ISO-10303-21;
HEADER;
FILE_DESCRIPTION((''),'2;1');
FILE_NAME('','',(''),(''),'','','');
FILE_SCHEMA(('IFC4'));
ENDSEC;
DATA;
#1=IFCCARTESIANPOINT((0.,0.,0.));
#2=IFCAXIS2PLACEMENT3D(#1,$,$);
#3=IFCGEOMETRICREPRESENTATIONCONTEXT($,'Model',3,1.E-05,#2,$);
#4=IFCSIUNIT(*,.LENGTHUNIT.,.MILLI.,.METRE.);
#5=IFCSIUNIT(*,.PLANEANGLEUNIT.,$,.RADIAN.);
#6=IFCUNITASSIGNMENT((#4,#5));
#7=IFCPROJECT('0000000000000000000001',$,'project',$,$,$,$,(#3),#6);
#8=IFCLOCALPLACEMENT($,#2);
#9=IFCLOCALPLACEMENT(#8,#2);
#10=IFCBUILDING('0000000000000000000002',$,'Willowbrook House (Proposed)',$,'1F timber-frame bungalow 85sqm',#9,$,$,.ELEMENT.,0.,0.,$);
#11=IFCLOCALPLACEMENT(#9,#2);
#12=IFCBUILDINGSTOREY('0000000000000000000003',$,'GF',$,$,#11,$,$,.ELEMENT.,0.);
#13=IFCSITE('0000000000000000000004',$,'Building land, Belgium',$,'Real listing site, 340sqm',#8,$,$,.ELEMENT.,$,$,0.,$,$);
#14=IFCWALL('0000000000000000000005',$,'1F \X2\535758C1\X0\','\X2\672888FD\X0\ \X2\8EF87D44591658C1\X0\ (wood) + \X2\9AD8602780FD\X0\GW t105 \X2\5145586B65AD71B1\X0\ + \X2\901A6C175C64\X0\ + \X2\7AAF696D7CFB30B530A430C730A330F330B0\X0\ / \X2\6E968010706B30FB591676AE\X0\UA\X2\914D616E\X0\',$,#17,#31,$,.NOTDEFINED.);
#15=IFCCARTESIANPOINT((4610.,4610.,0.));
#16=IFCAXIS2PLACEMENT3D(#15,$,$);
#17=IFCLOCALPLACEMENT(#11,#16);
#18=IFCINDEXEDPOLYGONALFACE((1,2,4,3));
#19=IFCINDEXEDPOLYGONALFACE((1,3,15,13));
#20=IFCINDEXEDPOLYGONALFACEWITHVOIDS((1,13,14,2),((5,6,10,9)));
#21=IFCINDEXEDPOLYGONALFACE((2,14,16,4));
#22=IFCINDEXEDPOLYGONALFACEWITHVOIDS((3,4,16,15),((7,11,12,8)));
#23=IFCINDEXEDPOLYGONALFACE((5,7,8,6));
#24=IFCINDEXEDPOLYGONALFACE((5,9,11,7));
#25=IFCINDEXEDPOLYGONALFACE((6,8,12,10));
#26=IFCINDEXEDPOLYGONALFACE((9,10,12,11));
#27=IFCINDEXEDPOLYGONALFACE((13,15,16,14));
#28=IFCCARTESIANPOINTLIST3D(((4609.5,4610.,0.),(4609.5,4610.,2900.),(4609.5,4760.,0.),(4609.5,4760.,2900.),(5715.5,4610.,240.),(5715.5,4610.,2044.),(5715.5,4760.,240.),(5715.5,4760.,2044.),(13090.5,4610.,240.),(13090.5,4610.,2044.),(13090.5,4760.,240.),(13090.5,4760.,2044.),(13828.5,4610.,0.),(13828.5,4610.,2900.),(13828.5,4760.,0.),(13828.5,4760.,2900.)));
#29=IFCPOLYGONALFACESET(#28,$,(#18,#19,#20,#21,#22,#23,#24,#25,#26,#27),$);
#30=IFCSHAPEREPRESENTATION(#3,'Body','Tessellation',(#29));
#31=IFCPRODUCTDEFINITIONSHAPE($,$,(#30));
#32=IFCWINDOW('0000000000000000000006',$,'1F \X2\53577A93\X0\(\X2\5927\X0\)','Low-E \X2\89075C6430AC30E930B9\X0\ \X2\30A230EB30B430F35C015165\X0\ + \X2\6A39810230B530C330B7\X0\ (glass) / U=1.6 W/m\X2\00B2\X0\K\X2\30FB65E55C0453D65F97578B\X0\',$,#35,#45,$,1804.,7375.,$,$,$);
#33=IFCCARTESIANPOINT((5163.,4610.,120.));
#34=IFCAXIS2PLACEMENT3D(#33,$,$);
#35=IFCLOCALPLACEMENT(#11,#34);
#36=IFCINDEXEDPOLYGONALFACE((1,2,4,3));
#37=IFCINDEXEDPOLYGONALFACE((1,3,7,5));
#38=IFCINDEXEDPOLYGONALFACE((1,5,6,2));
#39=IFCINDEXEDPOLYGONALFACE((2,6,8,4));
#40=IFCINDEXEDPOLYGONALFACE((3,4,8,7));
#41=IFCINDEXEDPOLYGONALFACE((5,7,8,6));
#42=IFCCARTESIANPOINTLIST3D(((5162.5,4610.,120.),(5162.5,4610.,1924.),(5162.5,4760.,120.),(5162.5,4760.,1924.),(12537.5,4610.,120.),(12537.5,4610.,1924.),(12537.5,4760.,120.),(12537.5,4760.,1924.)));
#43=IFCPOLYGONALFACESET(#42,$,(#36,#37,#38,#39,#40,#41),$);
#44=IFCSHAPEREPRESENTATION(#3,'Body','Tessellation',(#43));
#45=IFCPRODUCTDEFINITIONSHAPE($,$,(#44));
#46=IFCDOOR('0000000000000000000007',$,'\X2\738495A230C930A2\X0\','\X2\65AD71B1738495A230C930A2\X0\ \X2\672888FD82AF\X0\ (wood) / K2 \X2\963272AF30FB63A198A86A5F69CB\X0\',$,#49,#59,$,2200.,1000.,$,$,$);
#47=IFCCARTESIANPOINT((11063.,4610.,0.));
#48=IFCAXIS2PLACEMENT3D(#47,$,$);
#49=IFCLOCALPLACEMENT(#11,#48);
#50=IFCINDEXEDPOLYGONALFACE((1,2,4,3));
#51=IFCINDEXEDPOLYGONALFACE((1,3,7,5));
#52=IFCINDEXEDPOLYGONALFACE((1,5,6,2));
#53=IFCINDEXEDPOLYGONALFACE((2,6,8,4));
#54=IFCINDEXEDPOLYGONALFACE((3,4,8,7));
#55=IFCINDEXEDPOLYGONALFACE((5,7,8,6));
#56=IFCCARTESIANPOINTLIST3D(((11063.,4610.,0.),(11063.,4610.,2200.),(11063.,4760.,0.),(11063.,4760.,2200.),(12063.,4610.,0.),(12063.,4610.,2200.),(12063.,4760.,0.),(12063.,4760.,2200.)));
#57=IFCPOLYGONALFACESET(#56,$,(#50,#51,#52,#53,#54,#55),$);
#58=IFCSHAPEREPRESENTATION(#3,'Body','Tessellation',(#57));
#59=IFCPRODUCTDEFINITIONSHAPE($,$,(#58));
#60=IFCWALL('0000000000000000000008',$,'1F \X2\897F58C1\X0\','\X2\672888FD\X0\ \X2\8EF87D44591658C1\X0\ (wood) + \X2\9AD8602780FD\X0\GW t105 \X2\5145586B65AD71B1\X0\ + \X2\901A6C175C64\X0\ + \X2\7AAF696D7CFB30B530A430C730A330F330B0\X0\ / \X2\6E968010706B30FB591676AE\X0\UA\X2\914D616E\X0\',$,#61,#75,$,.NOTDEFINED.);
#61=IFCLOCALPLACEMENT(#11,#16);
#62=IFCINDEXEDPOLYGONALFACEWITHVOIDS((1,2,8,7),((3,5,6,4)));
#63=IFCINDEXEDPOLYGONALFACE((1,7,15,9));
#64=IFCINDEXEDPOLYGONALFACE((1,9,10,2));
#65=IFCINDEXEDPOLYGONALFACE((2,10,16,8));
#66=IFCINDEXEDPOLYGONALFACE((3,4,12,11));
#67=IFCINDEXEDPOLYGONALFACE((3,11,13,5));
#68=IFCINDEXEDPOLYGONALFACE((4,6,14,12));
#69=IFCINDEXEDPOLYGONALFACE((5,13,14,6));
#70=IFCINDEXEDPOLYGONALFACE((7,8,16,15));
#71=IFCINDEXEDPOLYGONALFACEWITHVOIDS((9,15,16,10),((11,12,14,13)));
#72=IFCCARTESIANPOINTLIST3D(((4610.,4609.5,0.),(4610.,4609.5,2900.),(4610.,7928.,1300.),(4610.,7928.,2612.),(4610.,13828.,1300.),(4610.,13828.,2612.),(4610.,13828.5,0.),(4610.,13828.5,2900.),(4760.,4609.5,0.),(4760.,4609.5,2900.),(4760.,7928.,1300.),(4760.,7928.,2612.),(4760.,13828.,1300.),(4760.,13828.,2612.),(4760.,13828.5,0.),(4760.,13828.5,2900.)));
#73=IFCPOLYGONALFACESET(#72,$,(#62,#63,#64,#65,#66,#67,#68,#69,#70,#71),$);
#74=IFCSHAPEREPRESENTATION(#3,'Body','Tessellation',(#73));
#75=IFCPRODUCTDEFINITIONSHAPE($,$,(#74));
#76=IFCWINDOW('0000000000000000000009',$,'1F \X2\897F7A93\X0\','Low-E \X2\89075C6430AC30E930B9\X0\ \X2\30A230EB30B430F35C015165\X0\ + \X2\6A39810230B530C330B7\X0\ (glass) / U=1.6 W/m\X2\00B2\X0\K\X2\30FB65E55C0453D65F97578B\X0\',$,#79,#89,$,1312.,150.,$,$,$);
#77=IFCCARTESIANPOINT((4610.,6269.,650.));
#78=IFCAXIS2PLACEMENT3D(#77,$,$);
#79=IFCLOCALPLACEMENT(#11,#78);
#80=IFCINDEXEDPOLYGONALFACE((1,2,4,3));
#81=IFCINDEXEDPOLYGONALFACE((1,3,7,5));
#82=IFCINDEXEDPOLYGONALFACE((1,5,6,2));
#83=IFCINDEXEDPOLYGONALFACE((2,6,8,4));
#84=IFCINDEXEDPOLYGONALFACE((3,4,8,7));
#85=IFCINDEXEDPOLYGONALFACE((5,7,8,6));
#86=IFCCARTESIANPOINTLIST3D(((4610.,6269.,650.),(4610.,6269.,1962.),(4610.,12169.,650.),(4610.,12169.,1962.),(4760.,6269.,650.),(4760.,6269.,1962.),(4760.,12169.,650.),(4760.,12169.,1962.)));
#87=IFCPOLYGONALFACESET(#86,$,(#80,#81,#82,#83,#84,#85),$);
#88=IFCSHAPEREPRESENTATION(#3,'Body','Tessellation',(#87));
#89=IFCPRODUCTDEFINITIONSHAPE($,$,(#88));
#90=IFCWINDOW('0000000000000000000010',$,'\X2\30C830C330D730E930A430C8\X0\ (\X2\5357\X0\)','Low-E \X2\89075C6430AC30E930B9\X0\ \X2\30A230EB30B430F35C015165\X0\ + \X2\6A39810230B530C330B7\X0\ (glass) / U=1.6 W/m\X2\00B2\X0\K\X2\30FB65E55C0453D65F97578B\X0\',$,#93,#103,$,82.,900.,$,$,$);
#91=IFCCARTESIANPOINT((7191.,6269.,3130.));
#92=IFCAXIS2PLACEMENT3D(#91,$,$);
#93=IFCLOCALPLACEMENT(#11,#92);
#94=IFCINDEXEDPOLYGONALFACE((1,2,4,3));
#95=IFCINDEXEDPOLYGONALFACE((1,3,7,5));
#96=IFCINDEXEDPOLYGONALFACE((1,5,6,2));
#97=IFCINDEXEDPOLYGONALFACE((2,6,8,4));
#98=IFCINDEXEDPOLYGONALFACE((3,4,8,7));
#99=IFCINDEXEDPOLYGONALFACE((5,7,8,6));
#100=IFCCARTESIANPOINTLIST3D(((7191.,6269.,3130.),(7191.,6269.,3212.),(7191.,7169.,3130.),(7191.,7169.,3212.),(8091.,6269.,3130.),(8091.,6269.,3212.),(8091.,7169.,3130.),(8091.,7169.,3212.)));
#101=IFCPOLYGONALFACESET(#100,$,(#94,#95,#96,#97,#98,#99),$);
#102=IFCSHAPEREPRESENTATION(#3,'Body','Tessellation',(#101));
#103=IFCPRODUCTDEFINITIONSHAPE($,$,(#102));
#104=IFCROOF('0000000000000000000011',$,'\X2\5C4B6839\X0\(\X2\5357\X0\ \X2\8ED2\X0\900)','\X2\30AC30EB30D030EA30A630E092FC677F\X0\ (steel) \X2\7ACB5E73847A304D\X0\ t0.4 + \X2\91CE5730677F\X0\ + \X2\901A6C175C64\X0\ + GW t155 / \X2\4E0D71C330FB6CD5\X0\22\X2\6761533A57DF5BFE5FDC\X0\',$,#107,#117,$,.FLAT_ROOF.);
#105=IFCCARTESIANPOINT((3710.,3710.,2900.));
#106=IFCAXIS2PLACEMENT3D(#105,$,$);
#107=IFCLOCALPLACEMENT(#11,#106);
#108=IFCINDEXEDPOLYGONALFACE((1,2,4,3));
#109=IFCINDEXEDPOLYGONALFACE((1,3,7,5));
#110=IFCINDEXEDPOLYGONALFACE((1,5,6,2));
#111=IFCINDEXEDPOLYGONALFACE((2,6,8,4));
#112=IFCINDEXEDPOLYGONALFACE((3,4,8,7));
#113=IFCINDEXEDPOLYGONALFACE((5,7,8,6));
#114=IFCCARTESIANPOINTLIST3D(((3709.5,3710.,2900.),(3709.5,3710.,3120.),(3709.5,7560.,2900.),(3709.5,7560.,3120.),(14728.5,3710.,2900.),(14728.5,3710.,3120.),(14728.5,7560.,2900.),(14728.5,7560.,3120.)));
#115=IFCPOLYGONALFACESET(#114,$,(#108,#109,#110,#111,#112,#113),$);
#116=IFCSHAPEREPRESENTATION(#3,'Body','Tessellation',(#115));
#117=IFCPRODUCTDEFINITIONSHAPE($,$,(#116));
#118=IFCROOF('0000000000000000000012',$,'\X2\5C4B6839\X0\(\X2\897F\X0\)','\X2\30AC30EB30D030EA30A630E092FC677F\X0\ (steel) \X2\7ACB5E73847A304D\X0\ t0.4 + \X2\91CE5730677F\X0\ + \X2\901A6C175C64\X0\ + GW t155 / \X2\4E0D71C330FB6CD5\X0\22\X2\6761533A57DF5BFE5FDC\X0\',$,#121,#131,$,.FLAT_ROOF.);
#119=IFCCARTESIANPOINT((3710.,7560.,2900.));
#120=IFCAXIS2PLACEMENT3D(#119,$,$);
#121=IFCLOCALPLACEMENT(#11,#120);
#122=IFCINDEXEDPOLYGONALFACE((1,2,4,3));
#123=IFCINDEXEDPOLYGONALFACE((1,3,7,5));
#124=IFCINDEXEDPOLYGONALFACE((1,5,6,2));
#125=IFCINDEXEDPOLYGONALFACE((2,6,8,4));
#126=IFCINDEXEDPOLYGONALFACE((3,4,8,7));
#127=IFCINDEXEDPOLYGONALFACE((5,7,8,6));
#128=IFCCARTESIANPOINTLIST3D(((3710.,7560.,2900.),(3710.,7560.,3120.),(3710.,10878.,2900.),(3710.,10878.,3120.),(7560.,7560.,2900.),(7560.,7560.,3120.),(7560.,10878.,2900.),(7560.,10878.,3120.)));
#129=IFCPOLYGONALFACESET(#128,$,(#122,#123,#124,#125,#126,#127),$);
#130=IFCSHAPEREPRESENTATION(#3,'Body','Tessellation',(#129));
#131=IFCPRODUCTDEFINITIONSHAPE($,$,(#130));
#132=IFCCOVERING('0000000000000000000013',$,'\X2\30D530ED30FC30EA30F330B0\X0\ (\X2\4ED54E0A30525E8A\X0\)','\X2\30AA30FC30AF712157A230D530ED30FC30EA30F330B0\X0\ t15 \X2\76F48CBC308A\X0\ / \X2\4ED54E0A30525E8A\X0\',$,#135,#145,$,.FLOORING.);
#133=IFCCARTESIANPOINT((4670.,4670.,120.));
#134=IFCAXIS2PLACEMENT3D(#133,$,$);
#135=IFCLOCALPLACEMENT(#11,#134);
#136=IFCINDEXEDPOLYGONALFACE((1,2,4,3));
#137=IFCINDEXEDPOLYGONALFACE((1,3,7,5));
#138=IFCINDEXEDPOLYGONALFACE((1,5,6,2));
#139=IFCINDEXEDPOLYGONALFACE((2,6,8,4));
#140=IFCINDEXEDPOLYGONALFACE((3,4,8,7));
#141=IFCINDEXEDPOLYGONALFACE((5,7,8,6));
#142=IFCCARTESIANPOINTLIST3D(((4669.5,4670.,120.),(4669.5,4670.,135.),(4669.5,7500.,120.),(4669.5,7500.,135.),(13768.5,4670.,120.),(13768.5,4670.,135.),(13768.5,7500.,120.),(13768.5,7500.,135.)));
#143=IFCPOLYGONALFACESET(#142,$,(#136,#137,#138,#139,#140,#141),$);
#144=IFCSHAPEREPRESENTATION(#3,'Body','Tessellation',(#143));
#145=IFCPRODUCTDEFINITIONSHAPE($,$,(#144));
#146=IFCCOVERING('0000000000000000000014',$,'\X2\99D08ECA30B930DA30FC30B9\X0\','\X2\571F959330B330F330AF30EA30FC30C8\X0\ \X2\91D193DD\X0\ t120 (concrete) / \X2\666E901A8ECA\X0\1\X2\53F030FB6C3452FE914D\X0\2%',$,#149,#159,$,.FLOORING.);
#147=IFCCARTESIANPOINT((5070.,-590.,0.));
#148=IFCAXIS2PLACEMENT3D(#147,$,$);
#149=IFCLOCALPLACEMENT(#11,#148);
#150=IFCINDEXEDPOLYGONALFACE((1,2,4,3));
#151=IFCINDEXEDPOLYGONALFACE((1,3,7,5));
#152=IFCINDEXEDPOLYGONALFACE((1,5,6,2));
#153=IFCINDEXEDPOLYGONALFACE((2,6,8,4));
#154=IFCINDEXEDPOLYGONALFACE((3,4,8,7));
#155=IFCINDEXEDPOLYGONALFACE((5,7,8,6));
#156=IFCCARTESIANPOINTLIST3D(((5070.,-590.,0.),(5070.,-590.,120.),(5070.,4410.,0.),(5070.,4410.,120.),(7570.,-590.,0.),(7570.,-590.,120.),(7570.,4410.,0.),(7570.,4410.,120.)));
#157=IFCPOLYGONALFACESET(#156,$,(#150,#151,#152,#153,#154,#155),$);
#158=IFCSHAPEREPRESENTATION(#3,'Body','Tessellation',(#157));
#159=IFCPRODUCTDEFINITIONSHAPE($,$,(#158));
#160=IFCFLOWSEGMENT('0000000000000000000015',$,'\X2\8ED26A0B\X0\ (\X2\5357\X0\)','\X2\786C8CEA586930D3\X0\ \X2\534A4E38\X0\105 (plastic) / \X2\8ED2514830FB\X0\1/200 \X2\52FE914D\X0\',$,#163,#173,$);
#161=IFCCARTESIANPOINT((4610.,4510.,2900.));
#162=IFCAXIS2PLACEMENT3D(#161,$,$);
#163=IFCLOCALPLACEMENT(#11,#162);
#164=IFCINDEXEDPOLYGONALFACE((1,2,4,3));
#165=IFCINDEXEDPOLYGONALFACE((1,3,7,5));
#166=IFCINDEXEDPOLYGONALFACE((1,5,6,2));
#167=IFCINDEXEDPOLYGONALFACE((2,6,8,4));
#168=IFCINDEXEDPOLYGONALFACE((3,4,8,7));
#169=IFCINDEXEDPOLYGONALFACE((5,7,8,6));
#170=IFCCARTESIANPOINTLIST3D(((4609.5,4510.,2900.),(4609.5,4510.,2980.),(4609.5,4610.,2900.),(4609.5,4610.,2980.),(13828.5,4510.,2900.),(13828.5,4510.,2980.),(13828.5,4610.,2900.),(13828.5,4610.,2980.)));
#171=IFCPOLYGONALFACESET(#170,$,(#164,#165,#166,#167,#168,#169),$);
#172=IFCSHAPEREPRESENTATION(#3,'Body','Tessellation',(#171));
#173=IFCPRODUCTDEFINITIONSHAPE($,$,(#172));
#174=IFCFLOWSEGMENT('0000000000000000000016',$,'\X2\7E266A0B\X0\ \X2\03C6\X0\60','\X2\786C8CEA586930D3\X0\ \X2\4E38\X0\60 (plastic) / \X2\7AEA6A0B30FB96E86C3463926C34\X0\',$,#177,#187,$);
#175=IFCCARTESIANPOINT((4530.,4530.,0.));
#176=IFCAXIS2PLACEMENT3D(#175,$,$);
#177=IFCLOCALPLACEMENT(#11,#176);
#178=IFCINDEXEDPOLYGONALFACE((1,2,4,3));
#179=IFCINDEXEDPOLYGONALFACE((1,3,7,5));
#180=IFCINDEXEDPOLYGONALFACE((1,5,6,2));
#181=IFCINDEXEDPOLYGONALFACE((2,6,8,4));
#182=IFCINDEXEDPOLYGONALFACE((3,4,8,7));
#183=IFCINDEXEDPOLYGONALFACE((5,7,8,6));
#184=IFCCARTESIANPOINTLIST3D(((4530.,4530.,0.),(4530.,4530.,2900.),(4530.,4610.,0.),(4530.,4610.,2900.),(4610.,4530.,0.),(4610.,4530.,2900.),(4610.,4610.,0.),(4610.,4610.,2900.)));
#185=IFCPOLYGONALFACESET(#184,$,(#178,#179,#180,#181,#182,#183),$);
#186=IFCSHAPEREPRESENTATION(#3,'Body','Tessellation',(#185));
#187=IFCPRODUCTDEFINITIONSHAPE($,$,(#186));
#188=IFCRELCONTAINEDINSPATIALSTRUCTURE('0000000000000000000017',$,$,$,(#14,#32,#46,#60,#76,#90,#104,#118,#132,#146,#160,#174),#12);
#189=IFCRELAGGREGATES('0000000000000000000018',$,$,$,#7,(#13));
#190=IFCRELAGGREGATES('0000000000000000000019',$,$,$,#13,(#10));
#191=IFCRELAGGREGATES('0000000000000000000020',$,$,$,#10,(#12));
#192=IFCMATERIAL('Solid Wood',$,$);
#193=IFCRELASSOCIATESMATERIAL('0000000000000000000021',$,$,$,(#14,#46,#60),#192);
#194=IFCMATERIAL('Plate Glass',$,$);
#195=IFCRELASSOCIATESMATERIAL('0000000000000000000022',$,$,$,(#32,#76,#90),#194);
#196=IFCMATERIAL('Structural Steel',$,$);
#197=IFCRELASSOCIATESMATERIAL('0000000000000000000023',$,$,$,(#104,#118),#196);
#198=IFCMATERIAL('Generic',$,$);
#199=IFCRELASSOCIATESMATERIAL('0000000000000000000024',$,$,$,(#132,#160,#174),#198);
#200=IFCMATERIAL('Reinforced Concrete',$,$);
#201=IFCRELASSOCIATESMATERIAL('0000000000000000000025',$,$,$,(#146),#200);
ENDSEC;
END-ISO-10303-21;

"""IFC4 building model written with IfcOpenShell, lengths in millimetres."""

from ifc_helpers import new_model, si_unit, frame, frame_2d, origin, place, context, project, spatial, rectangle, extrude, material, element, fill, save


model = new_model("IFC4")

# Units and contexts
model_context = context("Model", 3, precision=1e-05, world=origin())
ifc_project = project(units=[si_unit("LENGTHUNIT", "METRE", prefix="MILLI"), si_unit("PLANEANGLEUNIT", "RADIAN")], contexts=[model_context])

# Site, building, storey
site_placement = place(None, origin())
site = spatial("IfcSite", under=ifc_project, at=site_placement, Name="Building land, Belgium", ObjectType="Real listing site, 340sqm", CompositionType="ELEMENT", RefElevation=0.0)
building_placement = place(site_placement, origin())
building = spatial("IfcBuilding", under=site, at=building_placement, Name="Willowbrook House (Proposed)", ObjectType="1F timber-frame bungalow 85sqm", CompositionType="ELEMENT", ElevationOfRefHeight=0.0, ElevationOfTerrain=0.0)
storey_placement = place(building_placement, origin())
storey = spatial("IfcBuildingStorey", under=building, at=storey_placement, Name="GF", CompositionType="ELEMENT", Elevation=0.0)

# Shared definitions
ifc_material_1 = material(Name="Solid Wood")

# Shared definitions
ifc_material_2 = material(Name="Reinforced Concrete")

# Wall, openings, window, door
wall_1_placement = place(storey_placement, frame((4610.0, 4610.0, 0.0)))
wall_1 = element("IfcWall", 1, at=wall_1_placement, inside=storey, material=ifc_material_1, Name="1F 南壁", Description="木製 軸組外壁 (wood) + 高性能GW t105 充填断熱 + 通気層 + 窯業系サイディング / 準耐火・外皮UA配慮", PredefinedType="NOTDEFINED", context=model_context, shape_type="SweptSolid", body=[
    extrude(rectangle(XDim=9219.0, YDim=150.0, at=frame_2d((4609.0, 75.0))), frame((4610.0, 4610.0, 0.0)), (0.0, 0.0, 1.0), 2900.0),
])
opening_1_placement = place(storey_placement, frame((5163.0, 4610.0, 120.0)))
opening_1 = element("IfcOpeningElement", 2, at=opening_1_placement, cuts=wall_1, PredefinedType="NOTDEFINED", context=model_context, shape_type="SweptSolid", body=[
    extrude(rectangle(XDim=7375.0, YDim=150.0, at=frame_2d((3687.0, 75.0))), frame((5163.0, 4610.0, 120.0)), (0.0, 0.0, 1.0), 1804.0),
])
opening_2_placement = place(storey_placement, frame((11063.0, 4610.0, 0.0)))
opening_2 = element("IfcOpeningElement", 3, at=opening_2_placement, cuts=wall_1, PredefinedType="NOTDEFINED", context=model_context, shape_type="SweptSolid", body=[
    extrude(rectangle(XDim=1000.0, YDim=150.0, at=frame_2d((500.0, 75.0))), frame((11063.0, 4610.0, 0.0)), (0.0, 0.0, 1.0), 2200.0),
])
ifc_material_3 = material(Name="Plate Glass")
window_1_placement = place(storey_placement, frame((5163.0, 4610.0, 120.0)))
window_1 = element("IfcWindow", 4, at=window_1_placement, inside=storey, material=ifc_material_3, Name="1F 南窓(大)", Description="Low-E 複層ガラス アルゴン封入 + 樹脂サッシ (glass) / U=1.6 W/m²K・日射取得型", OverallHeight=1804.0, OverallWidth=7375.0, context=model_context, shape_type="SweptSolid", body=[
    extrude(rectangle(XDim=7375.0, YDim=150.0, at=frame_2d((3687.0, 75.0))), frame((5163.0, 4610.0, 120.0)), (0.0, 0.0, 1.0), 1804.0),
])
fill(opening_1, window_1)
door_placement = place(storey_placement, frame((11063.0, 4610.0, 0.0)))
door = element("IfcDoor", 5, at=door_placement, inside=storey, material=ifc_material_1, Name="玄関ドア", Description="断熱玄関ドア 木製芯 (wood) / K2 防犯・採風機構", OverallHeight=2200.0, OverallWidth=1000.0, context=model_context, shape_type="SweptSolid", body=[
    extrude(rectangle(XDim=1000.0, YDim=150.0, at=frame_2d((500.0, 75.0))), frame((11063.0, 4610.0, 0.0)), (0.0, 0.0, 1.0), 2200.0),
])
fill(opening_2, door)

# Wall, opening, window
wall_2_placement = place(storey_placement, frame((4610.0, 4610.0, 0.0)))
wall_2 = element("IfcWall", 6, at=wall_2_placement, inside=storey, material=ifc_material_1, Name="1F 西壁", Description="木製 軸組外壁 (wood) + 高性能GW t105 充填断熱 + 通気層 + 窯業系サイディング / 準耐火・外皮UA配慮", PredefinedType="NOTDEFINED", context=model_context, shape_type="SweptSolid", body=[
    extrude(rectangle(XDim=150.0, YDim=9219.0, at=frame_2d((75.0, 4609.0))), frame((4610.0, 4610.0, 0.0)), (0.0, 0.0, 1.0), 2900.0),
])
opening_3_placement = place(storey_placement, frame((4610.0, 6269.0, 650.0)))
opening_3 = element("IfcOpeningElement", 7, at=opening_3_placement, cuts=wall_2, PredefinedType="NOTDEFINED", context=model_context, shape_type="SweptSolid", body=[
    extrude(rectangle(XDim=150.0, YDim=5900.0, at=frame_2d((75.0, 2950.0))), frame((4610.0, 6269.0, 650.0)), (0.0, 0.0, 1.0), 1312.0),
])
window_2_placement = place(storey_placement, frame((4610.0, 6269.0, 650.0)))
window_2 = element("IfcWindow", 8, at=window_2_placement, inside=storey, material=ifc_material_3, Name="1F 西窓", Description="Low-E 複層ガラス アルゴン封入 + 樹脂サッシ (glass) / U=1.6 W/m²K・日射取得型", OverallHeight=1312.0, OverallWidth=150.0, context=model_context, shape_type="SweptSolid", body=[
    extrude(rectangle(XDim=150.0, YDim=5900.0, at=frame_2d((75.0, 2950.0))), frame((4610.0, 6269.0, 650.0)), (0.0, 0.0, 1.0), 1312.0),
])
fill(opening_3, window_2)

# Window
window_3_placement = place(storey_placement, frame((7191.0, 6269.0, 3130.0)))
element("IfcWindow", 9, at=window_3_placement, inside=storey, material=ifc_material_3, Name="トップライト (南)", Description="Low-E 複層ガラス アルゴン封入 + 樹脂サッシ (glass) / U=1.6 W/m²K・日射取得型", OverallHeight=82.0, OverallWidth=900.0, context=model_context, shape_type="SweptSolid", body=[
    extrude(rectangle(XDim=900.0, YDim=900.0, at=frame_2d((450.0, 450.0))), frame((7191.0, 6269.0, 3130.0)), (0.0, 0.0, 1.0), 82.0),
])

# Roofs
ifc_material_4 = material(Name="Structural Steel")
roof_1_placement = place(storey_placement, frame((3710.0, 3710.0, 2900.0)))
element("IfcRoof", 10, at=roof_1_placement, inside=storey, material=ifc_material_4, Name="屋根(南 軒900)", Description="ガルバリウム鋼板 (steel) 立平葺き t0.4 + 野地板 + 通気層 + GW t155 / 不燃・法22条区域対応", PredefinedType="FLAT_ROOF", context=model_context, shape_type="SweptSolid", body=[
    extrude(rectangle(XDim=11019.0, YDim=3850.0, at=frame_2d((5509.0, 1925.0))), frame((3710.0, 3710.0, 2900.0)), (0.0, 0.0, 1.0), 220.0),
])
roof_2_placement = place(storey_placement, frame((3710.0, 7560.0, 2900.0)))
element("IfcRoof", 11, at=roof_2_placement, inside=storey, material=ifc_material_4, Name="屋根(西)", Description="ガルバリウム鋼板 (steel) 立平葺き t0.4 + 野地板 + 通気層 + GW t155 / 不燃・法22条区域対応", PredefinedType="FLAT_ROOF", context=model_context, shape_type="SweptSolid", body=[
    extrude(rectangle(XDim=3850.0, YDim=3318.0, at=frame_2d((1925.0, 1659.0))), frame((3710.0, 7560.0, 2900.0)), (0.0, 0.0, 1.0), 220.0),
])

# Coverings
ifc_material_5 = material(Name="Generic")
covering_1_placement = place(storey_placement, frame((4670.0, 4670.0, 120.0)))
element("IfcCovering", 12, at=covering_1_placement, inside=storey, material=ifc_material_5, Name="フローリング (仕上げ床)", Description="オーク無垢フローリング t15 直貼り / 仕上げ床", PredefinedType="FLOORING", context=model_context, shape_type="SweptSolid", body=[
    extrude(rectangle(XDim=9099.0, YDim=2830.0, at=frame_2d((4549.0, 1415.0))), frame((4670.0, 4670.0, 120.0)), (0.0, 0.0, 1.0), 15.0),
])
covering_2_placement = place(storey_placement, frame((5070.0, -590.0, 0.0)))
element("IfcCovering", 13, at=covering_2_placement, inside=storey, material=ifc_material_2, Name="駐車スペース", Description="土間コンクリート 金鏝 t120 (concrete) / 普通車1台・水勾配2%", PredefinedType="FLOORING", context=model_context, shape_type="SweptSolid", body=[
    extrude(rectangle(XDim=2500.0, YDim=5000.0, at=frame_2d((1250.0, 2500.0))), frame((5070.0, -590.0, 0.0)), (0.0, 0.0, 1.0), 120.0),
])

# Flow segments
flow_segment_1_placement = place(storey_placement, frame((4610.0, 4510.0, 2900.0)))
element("IfcFlowSegment", 14, at=flow_segment_1_placement, inside=storey, material=ifc_material_5, Name="軒樋 (南)", Description="硬質塩ビ 半丸105 (plastic) / 軒先・1/200 勾配", context=model_context, shape_type="SweptSolid", body=[
    extrude(rectangle(XDim=9219.0, YDim=100.0, at=frame_2d((4609.0, 50.0))), frame((4610.0, 4510.0, 2900.0)), (0.0, 0.0, 1.0), 80.0),
])
flow_segment_2_placement = place(storey_placement, frame((4530.0, 4530.0, 0.0)))
element("IfcFlowSegment", 15, at=flow_segment_2_placement, inside=storey, material=ifc_material_5, Name="縦樋 φ60", Description="硬質塩ビ 丸60 (plastic) / 竪樋・雨水排水", context=model_context, shape_type="SweptSolid", body=[
    extrude(rectangle(XDim=80.0, YDim=80.0, at=frame_2d((40.0, 40.0))), frame((4530.0, 4530.0, 0.0)), (0.0, 0.0, 1.0), 2900.0),
])

save(model, "model.ifc")
